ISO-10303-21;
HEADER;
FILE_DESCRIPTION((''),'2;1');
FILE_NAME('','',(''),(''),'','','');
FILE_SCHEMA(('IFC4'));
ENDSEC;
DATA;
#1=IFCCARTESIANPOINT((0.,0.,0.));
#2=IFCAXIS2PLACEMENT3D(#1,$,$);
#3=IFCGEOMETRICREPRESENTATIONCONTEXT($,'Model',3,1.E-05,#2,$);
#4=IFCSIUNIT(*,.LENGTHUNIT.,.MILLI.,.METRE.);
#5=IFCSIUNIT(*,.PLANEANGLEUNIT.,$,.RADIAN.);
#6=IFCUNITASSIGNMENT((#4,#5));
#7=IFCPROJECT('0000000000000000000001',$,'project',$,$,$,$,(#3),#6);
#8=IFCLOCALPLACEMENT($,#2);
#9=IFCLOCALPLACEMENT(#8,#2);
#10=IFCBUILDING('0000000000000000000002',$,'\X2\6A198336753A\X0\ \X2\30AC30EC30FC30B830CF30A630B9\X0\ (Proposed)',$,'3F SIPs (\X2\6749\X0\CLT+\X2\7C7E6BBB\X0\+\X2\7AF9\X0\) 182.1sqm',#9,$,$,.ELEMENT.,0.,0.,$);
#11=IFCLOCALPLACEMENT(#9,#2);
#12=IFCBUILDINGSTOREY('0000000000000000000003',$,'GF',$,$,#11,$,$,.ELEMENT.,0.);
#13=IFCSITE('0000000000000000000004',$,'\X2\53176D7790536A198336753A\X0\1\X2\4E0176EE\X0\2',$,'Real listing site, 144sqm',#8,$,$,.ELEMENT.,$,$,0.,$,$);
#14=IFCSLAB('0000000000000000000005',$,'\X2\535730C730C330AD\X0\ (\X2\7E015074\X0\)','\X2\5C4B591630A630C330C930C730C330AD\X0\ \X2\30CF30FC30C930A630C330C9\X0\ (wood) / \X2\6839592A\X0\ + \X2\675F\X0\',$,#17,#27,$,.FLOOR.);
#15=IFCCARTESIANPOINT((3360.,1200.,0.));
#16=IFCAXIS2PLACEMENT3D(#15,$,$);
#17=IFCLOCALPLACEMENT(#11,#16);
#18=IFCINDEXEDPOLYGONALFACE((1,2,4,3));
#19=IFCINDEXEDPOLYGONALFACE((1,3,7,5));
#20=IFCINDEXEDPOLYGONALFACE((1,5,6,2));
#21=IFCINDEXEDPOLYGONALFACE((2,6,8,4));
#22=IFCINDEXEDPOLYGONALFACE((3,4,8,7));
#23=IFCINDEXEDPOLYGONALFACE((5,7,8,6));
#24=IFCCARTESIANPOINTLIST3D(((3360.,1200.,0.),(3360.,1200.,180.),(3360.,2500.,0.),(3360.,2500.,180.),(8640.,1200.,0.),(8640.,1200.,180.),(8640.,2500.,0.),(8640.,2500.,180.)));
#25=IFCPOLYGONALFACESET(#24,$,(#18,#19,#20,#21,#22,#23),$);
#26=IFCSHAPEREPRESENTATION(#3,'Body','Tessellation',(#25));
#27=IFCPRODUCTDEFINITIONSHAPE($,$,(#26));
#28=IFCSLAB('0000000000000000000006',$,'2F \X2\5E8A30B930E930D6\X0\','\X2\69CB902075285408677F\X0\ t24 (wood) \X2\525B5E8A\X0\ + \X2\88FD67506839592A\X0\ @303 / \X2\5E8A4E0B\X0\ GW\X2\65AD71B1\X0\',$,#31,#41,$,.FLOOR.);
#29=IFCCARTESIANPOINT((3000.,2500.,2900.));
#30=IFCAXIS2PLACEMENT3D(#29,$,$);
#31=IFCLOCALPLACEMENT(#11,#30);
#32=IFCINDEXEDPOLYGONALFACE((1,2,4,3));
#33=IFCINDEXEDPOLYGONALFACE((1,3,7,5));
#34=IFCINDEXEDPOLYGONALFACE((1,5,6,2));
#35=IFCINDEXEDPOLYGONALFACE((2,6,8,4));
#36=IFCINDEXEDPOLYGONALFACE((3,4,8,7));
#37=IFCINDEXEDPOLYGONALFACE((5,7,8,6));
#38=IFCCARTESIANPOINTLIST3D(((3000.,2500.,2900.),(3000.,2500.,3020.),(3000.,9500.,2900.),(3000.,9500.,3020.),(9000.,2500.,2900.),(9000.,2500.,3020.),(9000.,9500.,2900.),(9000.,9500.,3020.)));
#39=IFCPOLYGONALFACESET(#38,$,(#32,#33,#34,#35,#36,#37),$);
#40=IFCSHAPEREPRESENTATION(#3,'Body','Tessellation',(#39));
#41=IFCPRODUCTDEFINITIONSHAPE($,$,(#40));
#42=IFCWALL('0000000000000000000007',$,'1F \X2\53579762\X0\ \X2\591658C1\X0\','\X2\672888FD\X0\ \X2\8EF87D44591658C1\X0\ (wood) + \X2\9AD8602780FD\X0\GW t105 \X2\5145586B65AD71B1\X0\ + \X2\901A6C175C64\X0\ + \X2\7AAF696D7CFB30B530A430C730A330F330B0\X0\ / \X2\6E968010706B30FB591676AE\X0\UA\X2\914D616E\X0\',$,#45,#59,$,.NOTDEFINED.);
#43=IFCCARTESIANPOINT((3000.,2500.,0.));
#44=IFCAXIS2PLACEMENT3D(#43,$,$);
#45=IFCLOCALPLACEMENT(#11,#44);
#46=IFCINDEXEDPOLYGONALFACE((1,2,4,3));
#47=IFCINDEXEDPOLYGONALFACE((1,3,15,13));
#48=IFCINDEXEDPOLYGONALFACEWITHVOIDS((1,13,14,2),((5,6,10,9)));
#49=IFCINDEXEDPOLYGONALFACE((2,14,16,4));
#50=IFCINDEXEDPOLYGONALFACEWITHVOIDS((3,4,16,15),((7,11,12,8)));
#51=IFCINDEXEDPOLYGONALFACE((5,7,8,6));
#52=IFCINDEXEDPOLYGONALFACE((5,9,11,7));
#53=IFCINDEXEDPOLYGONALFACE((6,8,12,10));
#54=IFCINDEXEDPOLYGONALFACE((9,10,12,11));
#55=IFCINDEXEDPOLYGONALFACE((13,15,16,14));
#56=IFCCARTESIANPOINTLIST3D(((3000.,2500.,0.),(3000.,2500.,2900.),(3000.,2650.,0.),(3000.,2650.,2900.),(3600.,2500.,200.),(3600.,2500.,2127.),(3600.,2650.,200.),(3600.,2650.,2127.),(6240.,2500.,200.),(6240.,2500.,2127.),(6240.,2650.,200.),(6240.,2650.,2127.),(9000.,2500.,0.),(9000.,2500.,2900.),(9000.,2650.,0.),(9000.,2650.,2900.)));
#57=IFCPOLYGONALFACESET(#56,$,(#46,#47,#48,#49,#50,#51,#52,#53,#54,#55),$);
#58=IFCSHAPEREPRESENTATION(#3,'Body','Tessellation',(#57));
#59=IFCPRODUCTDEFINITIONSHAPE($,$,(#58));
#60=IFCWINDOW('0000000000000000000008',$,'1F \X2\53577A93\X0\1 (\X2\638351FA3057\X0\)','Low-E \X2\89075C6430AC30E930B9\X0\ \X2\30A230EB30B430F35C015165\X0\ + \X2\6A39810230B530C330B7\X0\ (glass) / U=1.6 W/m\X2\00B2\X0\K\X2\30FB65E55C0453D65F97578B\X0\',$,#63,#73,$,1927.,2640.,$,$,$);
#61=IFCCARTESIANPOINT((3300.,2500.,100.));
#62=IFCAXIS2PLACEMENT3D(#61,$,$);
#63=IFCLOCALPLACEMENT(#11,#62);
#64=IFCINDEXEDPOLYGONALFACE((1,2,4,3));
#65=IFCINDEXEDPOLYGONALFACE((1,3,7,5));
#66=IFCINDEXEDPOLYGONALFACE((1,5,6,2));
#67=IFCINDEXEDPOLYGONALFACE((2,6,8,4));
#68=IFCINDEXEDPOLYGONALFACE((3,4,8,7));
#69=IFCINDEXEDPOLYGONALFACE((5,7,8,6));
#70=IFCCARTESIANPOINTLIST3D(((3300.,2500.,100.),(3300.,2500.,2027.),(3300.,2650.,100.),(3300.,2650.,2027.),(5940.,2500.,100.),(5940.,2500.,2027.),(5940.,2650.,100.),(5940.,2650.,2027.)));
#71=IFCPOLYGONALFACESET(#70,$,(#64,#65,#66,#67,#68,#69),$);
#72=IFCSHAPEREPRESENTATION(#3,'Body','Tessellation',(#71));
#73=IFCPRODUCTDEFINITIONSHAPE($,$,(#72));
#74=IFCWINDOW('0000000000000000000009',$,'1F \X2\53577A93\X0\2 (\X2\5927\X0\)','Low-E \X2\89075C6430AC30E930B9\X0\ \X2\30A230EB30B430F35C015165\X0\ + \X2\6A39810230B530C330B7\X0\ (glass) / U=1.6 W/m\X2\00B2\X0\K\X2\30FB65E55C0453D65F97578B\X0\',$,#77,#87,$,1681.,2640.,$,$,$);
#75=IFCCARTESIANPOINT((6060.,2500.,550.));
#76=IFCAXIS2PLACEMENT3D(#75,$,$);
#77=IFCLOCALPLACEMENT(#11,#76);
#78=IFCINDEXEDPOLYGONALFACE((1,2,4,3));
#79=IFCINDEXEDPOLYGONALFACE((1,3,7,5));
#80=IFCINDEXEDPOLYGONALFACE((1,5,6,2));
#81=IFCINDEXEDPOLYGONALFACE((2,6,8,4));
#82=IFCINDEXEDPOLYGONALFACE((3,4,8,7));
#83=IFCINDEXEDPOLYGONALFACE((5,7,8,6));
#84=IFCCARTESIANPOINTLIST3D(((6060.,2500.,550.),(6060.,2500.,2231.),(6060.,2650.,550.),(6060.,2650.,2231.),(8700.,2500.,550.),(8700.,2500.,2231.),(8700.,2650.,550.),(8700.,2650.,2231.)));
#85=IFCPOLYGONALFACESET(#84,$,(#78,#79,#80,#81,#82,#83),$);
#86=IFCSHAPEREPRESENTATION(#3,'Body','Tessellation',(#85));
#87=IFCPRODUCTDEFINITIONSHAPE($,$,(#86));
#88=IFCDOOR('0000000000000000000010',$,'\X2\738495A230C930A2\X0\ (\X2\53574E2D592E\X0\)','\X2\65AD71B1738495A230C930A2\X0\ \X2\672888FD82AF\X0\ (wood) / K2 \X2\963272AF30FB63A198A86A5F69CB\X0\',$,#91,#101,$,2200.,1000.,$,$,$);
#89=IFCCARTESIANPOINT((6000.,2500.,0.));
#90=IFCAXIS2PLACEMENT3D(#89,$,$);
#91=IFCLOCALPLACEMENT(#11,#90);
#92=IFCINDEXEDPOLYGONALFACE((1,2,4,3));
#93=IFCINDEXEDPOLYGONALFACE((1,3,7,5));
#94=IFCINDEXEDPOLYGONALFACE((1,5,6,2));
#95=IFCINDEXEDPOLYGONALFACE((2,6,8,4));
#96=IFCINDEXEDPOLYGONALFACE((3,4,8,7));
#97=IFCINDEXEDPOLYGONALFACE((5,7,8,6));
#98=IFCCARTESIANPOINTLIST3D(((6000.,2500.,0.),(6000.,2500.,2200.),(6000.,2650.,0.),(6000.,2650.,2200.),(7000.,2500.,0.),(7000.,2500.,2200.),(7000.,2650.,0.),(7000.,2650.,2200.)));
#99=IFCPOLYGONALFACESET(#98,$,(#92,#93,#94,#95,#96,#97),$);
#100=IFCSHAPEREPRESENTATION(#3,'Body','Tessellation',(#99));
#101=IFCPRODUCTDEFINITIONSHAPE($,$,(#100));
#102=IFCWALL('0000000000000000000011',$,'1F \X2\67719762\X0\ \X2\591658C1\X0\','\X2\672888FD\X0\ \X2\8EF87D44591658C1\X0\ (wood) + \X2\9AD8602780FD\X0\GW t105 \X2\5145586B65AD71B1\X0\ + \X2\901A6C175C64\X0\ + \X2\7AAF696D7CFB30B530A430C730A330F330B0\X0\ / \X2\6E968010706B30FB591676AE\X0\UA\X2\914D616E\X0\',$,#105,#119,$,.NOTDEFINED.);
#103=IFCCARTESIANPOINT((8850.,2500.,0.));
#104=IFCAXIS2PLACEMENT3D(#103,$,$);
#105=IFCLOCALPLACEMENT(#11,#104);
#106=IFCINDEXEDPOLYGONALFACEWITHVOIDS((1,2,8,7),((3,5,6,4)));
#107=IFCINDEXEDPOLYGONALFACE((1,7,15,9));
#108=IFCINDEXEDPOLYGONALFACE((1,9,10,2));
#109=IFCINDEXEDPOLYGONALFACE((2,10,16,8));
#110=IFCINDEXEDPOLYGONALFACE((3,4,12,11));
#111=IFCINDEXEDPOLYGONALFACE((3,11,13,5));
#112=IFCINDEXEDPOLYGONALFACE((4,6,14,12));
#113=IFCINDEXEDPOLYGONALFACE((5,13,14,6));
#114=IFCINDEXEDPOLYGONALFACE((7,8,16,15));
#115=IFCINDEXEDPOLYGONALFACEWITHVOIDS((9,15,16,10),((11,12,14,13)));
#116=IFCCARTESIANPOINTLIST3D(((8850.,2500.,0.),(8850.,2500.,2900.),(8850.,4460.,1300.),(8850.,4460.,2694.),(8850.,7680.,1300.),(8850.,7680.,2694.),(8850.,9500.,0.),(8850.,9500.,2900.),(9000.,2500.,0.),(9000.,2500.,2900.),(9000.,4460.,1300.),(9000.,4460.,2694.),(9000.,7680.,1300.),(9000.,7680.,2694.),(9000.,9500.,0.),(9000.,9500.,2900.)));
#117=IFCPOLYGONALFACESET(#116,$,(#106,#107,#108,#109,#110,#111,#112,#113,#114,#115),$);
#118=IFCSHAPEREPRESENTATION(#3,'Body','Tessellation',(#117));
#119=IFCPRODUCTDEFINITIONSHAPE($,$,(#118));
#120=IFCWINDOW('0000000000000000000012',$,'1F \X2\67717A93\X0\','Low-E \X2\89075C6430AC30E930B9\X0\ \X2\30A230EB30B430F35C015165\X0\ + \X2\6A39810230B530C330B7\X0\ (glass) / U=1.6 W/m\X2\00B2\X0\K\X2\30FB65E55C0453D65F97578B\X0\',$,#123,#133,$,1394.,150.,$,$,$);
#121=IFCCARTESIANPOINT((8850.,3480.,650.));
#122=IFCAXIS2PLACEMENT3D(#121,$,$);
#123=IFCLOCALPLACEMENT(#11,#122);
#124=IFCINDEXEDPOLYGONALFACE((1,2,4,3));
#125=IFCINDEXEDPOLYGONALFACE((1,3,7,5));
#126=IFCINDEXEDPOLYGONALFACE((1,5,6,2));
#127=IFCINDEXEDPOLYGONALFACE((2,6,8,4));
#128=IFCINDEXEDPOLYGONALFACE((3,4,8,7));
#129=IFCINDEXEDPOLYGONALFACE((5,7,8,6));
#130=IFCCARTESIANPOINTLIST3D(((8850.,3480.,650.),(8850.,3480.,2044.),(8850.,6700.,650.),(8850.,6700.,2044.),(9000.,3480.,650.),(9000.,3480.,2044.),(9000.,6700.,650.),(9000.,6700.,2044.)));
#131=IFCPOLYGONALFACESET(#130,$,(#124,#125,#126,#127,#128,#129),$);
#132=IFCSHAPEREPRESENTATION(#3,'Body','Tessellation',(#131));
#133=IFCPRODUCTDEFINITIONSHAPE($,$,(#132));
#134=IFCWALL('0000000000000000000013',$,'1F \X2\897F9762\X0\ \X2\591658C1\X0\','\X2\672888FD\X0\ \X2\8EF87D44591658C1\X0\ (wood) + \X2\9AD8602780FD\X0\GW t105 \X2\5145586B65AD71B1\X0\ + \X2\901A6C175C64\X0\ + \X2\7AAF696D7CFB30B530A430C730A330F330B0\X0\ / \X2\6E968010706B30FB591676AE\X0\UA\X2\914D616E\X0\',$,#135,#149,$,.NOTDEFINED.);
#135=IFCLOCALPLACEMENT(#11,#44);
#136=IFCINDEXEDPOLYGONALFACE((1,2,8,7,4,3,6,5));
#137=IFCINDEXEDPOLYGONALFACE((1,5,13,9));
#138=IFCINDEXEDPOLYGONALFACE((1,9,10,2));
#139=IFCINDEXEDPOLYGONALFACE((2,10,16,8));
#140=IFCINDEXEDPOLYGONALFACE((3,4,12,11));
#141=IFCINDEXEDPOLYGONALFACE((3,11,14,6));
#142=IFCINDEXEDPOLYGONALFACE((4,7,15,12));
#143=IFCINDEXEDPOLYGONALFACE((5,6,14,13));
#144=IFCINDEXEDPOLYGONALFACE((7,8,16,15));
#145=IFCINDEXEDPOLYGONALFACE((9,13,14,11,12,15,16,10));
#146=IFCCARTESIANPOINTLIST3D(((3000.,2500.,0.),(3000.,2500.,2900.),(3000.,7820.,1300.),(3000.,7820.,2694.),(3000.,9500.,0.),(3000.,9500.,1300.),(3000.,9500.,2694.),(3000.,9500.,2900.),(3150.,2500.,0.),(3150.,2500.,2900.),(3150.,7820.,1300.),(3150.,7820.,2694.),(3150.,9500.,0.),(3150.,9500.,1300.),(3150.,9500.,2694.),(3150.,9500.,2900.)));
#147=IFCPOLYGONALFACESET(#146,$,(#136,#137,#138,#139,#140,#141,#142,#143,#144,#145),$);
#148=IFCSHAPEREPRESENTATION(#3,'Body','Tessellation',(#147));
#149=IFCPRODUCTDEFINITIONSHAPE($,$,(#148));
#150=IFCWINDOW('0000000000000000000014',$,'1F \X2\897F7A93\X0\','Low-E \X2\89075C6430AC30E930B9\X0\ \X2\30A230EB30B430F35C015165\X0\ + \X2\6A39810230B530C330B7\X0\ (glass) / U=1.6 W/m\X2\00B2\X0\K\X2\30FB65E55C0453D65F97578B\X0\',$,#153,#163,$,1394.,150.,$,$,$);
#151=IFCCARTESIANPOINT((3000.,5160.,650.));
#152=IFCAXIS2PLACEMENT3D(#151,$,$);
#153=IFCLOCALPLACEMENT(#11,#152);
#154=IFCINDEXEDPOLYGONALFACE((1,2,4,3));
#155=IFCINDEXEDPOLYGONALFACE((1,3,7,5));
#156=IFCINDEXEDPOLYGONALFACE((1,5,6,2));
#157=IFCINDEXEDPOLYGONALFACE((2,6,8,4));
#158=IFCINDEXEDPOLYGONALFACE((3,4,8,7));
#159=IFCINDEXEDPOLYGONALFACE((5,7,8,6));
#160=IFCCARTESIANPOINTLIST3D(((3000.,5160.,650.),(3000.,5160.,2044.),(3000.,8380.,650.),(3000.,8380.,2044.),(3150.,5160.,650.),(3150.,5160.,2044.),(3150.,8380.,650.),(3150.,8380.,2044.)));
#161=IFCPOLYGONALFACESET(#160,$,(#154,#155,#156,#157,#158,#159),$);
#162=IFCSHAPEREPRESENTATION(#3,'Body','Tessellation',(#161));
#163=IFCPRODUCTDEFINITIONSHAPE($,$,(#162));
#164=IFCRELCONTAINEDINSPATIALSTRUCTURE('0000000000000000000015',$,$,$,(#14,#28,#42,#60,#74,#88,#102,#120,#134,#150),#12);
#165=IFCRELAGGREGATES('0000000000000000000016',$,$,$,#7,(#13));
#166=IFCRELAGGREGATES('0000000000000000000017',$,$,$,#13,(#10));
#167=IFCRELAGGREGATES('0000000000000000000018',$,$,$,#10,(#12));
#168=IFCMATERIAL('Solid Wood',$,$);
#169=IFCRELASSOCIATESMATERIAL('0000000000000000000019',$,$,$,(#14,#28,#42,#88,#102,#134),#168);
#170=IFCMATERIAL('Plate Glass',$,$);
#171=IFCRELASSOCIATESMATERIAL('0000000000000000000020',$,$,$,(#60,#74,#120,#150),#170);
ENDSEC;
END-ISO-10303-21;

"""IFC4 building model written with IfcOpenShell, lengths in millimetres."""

from ifc_helpers import new_model, si_unit, frame, frame_2d, origin, place, context, project, spatial, rectangle, extrude, material, element, fill, save


model = new_model("IFC4")

# Units and contexts
model_context = context("Model", 3, precision=1e-05, world=origin())
ifc_project = project(units=[si_unit("LENGTHUNIT", "METRE", prefix="MILLI"), si_unit("PLANEANGLEUNIT", "RADIAN")], contexts=[model_context])

# Site, building, storey
site_placement = place(None, origin())
site = spatial("IfcSite", under=ifc_project, at=site_placement, Name="北海道標茶町1丁目2", ObjectType="Real listing site, 144sqm", CompositionType="ELEMENT", RefElevation=0.0)
building_placement = place(site_placement, origin())
building = spatial("IfcBuilding", under=site, at=building_placement, Name="標茶町 ガレージハウス (Proposed)", ObjectType="3F SIPs (杉CLT+籾殻+竹) 182.1sqm", CompositionType="ELEMENT", ElevationOfRefHeight=0.0, ElevationOfTerrain=0.0)
storey_placement = place(building_placement, origin())
storey = spatial("IfcBuildingStorey", under=building, at=storey_placement, Name="GF", CompositionType="ELEMENT", Elevation=0.0)

# Slabs
ifc_material_1 = material(Name="Solid Wood")
slab_1_placement = place(storey_placement, frame((3360.0, 1200.0, 0.0)))
element("IfcSlab", 1, at=slab_1_placement, inside=storey, material=ifc_material_1, Name="南デッキ (縁側)", Description="屋外ウッドデッキ ハードウッド (wood) / 根太 + 束", PredefinedType="FLOOR", context=model_context, shape_type="SweptSolid", body=[
    extrude(rectangle(XDim=5280.0, YDim=1300.0, at=frame_2d((2640.0, 650.0))), frame((3360.0, 1200.0, 0.0)), (0.0, 0.0, 1.0), 180.0),
])
slab_2_placement = place(storey_placement, frame((3000.0, 2500.0, 2900.0)))
element("IfcSlab", 2, at=slab_2_placement, inside=storey, material=ifc_material_1, Name="2F 床スラブ", Description="構造用合板 t24 (wood) 剛床 + 製材根太 @303 / 床下 GW断熱", PredefinedType="FLOOR", context=model_context, shape_type="SweptSolid", body=[
    extrude(rectangle(XDim=6000.0, YDim=7000.0, at=frame_2d((3000.0, 3500.0))), frame((3000.0, 2500.0, 2900.0)), (0.0, 0.0, 1.0), 120.0),
])

# Wall, openings, windows, door
wall_1_placement = place(storey_placement, frame((3000.0, 2500.0, 0.0)))
wall_1 = element("IfcWall", 3, at=wall_1_placement, inside=storey, material=ifc_material_1, Name="1F 南面 外壁", Description="木製 軸組外壁 (wood) + 高性能GW t105 充填断熱 + 通気層 + 窯業系サイディング / 準耐火・外皮UA配慮", PredefinedType="NOTDEFINED", context=model_context, shape_type="SweptSolid", body=[
    extrude(rectangle(XDim=6000.0, YDim=150.0, at=frame_2d((3000.0, 75.0))), frame((3000.0, 2500.0, 0.0)), (0.0, 0.0, 1.0), 2900.0),
])
opening_1_placement = place(storey_placement, frame((3300.0, 2500.0, 100.0)))
opening_1 = element("IfcOpeningElement", 4, at=opening_1_placement, cuts=wall_1, PredefinedType="NOTDEFINED", context=model_context, shape_type="SweptSolid", body=[
    extrude(rectangle(XDim=2640.0, YDim=150.0, at=frame_2d((1320.0, 75.0))), frame((3300.0, 2500.0, 100.0)), (0.0, 0.0, 1.0), 1927.0),
])
opening_2_placement = place(storey_placement, frame((6060.0, 2500.0, 550.0)))
opening_2 = element("IfcOpeningElement", 5, at=opening_2_placement, cuts=wall_1, PredefinedType="NOTDEFINED", context=model_context, shape_type="SweptSolid", body=[
    extrude(rectangle(XDim=2640.0, YDim=150.0, at=frame_2d((1320.0, 75.0))), frame((6060.0, 2500.0, 550.0)), (0.0, 0.0, 1.0), 1681.0),
])
opening_3_placement = place(storey_placement, frame((6000.0, 2500.0, 0.0)))
opening_3 = element("IfcOpeningElement", 6, at=opening_3_placement, cuts=wall_1, PredefinedType="NOTDEFINED", context=model_context, shape_type="SweptSolid", body=[
    extrude(rectangle(XDim=1000.0, YDim=150.0, at=frame_2d((500.0, 75.0))), frame((6000.0, 2500.0, 0.0)), (0.0, 0.0, 1.0), 2200.0),
])
ifc_material_2 = material(Name="Plate Glass")
window_1_placement = place(storey_placement, frame((3300.0, 2500.0, 100.0)))
window_1 = element("IfcWindow", 7, at=window_1_placement, inside=storey, material=ifc_material_2, Name="1F 南窓1 (掃出し)", Description="Low-E 複層ガラス アルゴン封入 + 樹脂サッシ (glass) / U=1.6 W/m²K・日射取得型", OverallHeight=1927.0, OverallWidth=2640.0, context=model_context, shape_type="SweptSolid", body=[
    extrude(rectangle(XDim=2640.0, YDim=150.0, at=frame_2d((1320.0, 75.0))), frame((3300.0, 2500.0, 100.0)), (0.0, 0.0, 1.0), 1927.0),
])
fill(opening_1, window_1)
window_2_placement = place(storey_placement, frame((6060.0, 2500.0, 550.0)))
window_2 = element("IfcWindow", 8, at=window_2_placement, inside=storey, material=ifc_material_2, Name="1F 南窓2 (大)", Description="Low-E 複層ガラス アルゴン封入 + 樹脂サッシ (glass) / U=1.6 W/m²K・日射取得型", OverallHeight=1681.0, OverallWidth=2640.0, context=model_context, shape_type="SweptSolid", body=[
    extrude(rectangle(XDim=2640.0, YDim=150.0, at=frame_2d((1320.0, 75.0))), frame((6060.0, 2500.0, 550.0)), (0.0, 0.0, 1.0), 1681.0),
])
fill(opening_2, window_2)
door_placement = place(storey_placement, frame((6000.0, 2500.0, 0.0)))
door = element("IfcDoor", 9, at=door_placement, inside=storey, material=ifc_material_1, Name="玄関ドア (南中央)", Description="断熱玄関ドア 木製芯 (wood) / K2 防犯・採風機構", OverallHeight=2200.0, OverallWidth=1000.0, context=model_context, shape_type="SweptSolid", body=[
    extrude(rectangle(XDim=1000.0, YDim=150.0, at=frame_2d((500.0, 75.0))), frame((6000.0, 2500.0, 0.0)), (0.0, 0.0, 1.0), 2200.0),
])
fill(opening_3, door)

# Walls, openings, windows
wall_2_placement = place(storey_placement, frame((8850.0, 2500.0, 0.0)))
wall_2 = element("IfcWall", 10, at=wall_2_placement, inside=storey, material=ifc_material_1, Name="1F 東面 外壁", Description="木製 軸組外壁 (wood) + 高性能GW t105 充填断熱 + 通気層 + 窯業系サイディング / 準耐火・外皮UA配慮", PredefinedType="NOTDEFINED", context=model_context, shape_type="SweptSolid", body=[
    extrude(rectangle(XDim=150.0, YDim=7000.0, at=frame_2d((75.0, 3500.0))), frame((8850.0, 2500.0, 0.0)), (0.0, 0.0, 1.0), 2900.0),
])
opening_4_placement = place(storey_placement, frame((8850.0, 3480.0, 650.0)))
opening_4 = element("IfcOpeningElement", 11, at=opening_4_placement, cuts=wall_2, PredefinedType="NOTDEFINED", context=model_context, shape_type="SweptSolid", body=[
    extrude(rectangle(XDim=150.0, YDim=3220.0, at=frame_2d((75.0, 1610.0))), frame((8850.0, 3480.0, 650.0)), (0.0, 0.0, 1.0), 1394.0),
])
window_3_placement = place(storey_placement, frame((8850.0, 3480.0, 650.0)))
window_3 = element("IfcWindow", 12, at=window_3_placement, inside=storey, material=ifc_material_2, Name="1F 東窓", Description="Low-E 複層ガラス アルゴン封入 + 樹脂サッシ (glass) / U=1.6 W/m²K・日射取得型", OverallHeight=1394.0, OverallWidth=150.0, context=model_context, shape_type="SweptSolid", body=[
    extrude(rectangle(XDim=150.0, YDim=3220.0, at=frame_2d((75.0, 1610.0))), frame((8850.0, 3480.0, 650.0)), (0.0, 0.0, 1.0), 1394.0),
])
fill(opening_4, window_3)
wall_3_placement = place(storey_placement, frame((3000.0, 2500.0, 0.0)))
wall_3 = element("IfcWall", 13, at=wall_3_placement, inside=storey, material=ifc_material_1, Name="1F 西面 外壁", Description="木製 軸組外壁 (wood) + 高性能GW t105 充填断熱 + 通気層 + 窯業系サイディング / 準耐火・外皮UA配慮", PredefinedType="NOTDEFINED", context=model_context, shape_type="SweptSolid", body=[
    extrude(rectangle(XDim=150.0, YDim=7000.0, at=frame_2d((75.0, 3500.0))), frame((3000.0, 2500.0, 0.0)), (0.0, 0.0, 1.0), 2900.0),
])
opening_5_placement = place(storey_placement, frame((3000.0, 5160.0, 650.0)))
opening_5 = element("IfcOpeningElement", 14, at=opening_5_placement, cuts=wall_3, PredefinedType="NOTDEFINED", context=model_context, shape_type="SweptSolid", body=[
    extrude(rectangle(XDim=150.0, YDim=3220.0, at=frame_2d((75.0, 1610.0))), frame((3000.0, 5160.0, 650.0)), (0.0, 0.0, 1.0), 1394.0),
])
window_4_placement = place(storey_placement, frame((3000.0, 5160.0, 650.0)))
window_4 = element("IfcWindow", 15, at=window_4_placement, inside=storey, material=ifc_material_2, Name="1F 西窓", Description="Low-E 複層ガラス アルゴン封入 + 樹脂サッシ (glass) / U=1.6 W/m²K・日射取得型", OverallHeight=1394.0, OverallWidth=150.0, context=model_context, shape_type="SweptSolid", body=[
    extrude(rectangle(XDim=150.0, YDim=3220.0, at=frame_2d((75.0, 1610.0))), frame((3000.0, 5160.0, 650.0)), (0.0, 0.0, 1.0), 1394.0),
])
fill(opening_5, window_4)

save(model, "model.ifc")
